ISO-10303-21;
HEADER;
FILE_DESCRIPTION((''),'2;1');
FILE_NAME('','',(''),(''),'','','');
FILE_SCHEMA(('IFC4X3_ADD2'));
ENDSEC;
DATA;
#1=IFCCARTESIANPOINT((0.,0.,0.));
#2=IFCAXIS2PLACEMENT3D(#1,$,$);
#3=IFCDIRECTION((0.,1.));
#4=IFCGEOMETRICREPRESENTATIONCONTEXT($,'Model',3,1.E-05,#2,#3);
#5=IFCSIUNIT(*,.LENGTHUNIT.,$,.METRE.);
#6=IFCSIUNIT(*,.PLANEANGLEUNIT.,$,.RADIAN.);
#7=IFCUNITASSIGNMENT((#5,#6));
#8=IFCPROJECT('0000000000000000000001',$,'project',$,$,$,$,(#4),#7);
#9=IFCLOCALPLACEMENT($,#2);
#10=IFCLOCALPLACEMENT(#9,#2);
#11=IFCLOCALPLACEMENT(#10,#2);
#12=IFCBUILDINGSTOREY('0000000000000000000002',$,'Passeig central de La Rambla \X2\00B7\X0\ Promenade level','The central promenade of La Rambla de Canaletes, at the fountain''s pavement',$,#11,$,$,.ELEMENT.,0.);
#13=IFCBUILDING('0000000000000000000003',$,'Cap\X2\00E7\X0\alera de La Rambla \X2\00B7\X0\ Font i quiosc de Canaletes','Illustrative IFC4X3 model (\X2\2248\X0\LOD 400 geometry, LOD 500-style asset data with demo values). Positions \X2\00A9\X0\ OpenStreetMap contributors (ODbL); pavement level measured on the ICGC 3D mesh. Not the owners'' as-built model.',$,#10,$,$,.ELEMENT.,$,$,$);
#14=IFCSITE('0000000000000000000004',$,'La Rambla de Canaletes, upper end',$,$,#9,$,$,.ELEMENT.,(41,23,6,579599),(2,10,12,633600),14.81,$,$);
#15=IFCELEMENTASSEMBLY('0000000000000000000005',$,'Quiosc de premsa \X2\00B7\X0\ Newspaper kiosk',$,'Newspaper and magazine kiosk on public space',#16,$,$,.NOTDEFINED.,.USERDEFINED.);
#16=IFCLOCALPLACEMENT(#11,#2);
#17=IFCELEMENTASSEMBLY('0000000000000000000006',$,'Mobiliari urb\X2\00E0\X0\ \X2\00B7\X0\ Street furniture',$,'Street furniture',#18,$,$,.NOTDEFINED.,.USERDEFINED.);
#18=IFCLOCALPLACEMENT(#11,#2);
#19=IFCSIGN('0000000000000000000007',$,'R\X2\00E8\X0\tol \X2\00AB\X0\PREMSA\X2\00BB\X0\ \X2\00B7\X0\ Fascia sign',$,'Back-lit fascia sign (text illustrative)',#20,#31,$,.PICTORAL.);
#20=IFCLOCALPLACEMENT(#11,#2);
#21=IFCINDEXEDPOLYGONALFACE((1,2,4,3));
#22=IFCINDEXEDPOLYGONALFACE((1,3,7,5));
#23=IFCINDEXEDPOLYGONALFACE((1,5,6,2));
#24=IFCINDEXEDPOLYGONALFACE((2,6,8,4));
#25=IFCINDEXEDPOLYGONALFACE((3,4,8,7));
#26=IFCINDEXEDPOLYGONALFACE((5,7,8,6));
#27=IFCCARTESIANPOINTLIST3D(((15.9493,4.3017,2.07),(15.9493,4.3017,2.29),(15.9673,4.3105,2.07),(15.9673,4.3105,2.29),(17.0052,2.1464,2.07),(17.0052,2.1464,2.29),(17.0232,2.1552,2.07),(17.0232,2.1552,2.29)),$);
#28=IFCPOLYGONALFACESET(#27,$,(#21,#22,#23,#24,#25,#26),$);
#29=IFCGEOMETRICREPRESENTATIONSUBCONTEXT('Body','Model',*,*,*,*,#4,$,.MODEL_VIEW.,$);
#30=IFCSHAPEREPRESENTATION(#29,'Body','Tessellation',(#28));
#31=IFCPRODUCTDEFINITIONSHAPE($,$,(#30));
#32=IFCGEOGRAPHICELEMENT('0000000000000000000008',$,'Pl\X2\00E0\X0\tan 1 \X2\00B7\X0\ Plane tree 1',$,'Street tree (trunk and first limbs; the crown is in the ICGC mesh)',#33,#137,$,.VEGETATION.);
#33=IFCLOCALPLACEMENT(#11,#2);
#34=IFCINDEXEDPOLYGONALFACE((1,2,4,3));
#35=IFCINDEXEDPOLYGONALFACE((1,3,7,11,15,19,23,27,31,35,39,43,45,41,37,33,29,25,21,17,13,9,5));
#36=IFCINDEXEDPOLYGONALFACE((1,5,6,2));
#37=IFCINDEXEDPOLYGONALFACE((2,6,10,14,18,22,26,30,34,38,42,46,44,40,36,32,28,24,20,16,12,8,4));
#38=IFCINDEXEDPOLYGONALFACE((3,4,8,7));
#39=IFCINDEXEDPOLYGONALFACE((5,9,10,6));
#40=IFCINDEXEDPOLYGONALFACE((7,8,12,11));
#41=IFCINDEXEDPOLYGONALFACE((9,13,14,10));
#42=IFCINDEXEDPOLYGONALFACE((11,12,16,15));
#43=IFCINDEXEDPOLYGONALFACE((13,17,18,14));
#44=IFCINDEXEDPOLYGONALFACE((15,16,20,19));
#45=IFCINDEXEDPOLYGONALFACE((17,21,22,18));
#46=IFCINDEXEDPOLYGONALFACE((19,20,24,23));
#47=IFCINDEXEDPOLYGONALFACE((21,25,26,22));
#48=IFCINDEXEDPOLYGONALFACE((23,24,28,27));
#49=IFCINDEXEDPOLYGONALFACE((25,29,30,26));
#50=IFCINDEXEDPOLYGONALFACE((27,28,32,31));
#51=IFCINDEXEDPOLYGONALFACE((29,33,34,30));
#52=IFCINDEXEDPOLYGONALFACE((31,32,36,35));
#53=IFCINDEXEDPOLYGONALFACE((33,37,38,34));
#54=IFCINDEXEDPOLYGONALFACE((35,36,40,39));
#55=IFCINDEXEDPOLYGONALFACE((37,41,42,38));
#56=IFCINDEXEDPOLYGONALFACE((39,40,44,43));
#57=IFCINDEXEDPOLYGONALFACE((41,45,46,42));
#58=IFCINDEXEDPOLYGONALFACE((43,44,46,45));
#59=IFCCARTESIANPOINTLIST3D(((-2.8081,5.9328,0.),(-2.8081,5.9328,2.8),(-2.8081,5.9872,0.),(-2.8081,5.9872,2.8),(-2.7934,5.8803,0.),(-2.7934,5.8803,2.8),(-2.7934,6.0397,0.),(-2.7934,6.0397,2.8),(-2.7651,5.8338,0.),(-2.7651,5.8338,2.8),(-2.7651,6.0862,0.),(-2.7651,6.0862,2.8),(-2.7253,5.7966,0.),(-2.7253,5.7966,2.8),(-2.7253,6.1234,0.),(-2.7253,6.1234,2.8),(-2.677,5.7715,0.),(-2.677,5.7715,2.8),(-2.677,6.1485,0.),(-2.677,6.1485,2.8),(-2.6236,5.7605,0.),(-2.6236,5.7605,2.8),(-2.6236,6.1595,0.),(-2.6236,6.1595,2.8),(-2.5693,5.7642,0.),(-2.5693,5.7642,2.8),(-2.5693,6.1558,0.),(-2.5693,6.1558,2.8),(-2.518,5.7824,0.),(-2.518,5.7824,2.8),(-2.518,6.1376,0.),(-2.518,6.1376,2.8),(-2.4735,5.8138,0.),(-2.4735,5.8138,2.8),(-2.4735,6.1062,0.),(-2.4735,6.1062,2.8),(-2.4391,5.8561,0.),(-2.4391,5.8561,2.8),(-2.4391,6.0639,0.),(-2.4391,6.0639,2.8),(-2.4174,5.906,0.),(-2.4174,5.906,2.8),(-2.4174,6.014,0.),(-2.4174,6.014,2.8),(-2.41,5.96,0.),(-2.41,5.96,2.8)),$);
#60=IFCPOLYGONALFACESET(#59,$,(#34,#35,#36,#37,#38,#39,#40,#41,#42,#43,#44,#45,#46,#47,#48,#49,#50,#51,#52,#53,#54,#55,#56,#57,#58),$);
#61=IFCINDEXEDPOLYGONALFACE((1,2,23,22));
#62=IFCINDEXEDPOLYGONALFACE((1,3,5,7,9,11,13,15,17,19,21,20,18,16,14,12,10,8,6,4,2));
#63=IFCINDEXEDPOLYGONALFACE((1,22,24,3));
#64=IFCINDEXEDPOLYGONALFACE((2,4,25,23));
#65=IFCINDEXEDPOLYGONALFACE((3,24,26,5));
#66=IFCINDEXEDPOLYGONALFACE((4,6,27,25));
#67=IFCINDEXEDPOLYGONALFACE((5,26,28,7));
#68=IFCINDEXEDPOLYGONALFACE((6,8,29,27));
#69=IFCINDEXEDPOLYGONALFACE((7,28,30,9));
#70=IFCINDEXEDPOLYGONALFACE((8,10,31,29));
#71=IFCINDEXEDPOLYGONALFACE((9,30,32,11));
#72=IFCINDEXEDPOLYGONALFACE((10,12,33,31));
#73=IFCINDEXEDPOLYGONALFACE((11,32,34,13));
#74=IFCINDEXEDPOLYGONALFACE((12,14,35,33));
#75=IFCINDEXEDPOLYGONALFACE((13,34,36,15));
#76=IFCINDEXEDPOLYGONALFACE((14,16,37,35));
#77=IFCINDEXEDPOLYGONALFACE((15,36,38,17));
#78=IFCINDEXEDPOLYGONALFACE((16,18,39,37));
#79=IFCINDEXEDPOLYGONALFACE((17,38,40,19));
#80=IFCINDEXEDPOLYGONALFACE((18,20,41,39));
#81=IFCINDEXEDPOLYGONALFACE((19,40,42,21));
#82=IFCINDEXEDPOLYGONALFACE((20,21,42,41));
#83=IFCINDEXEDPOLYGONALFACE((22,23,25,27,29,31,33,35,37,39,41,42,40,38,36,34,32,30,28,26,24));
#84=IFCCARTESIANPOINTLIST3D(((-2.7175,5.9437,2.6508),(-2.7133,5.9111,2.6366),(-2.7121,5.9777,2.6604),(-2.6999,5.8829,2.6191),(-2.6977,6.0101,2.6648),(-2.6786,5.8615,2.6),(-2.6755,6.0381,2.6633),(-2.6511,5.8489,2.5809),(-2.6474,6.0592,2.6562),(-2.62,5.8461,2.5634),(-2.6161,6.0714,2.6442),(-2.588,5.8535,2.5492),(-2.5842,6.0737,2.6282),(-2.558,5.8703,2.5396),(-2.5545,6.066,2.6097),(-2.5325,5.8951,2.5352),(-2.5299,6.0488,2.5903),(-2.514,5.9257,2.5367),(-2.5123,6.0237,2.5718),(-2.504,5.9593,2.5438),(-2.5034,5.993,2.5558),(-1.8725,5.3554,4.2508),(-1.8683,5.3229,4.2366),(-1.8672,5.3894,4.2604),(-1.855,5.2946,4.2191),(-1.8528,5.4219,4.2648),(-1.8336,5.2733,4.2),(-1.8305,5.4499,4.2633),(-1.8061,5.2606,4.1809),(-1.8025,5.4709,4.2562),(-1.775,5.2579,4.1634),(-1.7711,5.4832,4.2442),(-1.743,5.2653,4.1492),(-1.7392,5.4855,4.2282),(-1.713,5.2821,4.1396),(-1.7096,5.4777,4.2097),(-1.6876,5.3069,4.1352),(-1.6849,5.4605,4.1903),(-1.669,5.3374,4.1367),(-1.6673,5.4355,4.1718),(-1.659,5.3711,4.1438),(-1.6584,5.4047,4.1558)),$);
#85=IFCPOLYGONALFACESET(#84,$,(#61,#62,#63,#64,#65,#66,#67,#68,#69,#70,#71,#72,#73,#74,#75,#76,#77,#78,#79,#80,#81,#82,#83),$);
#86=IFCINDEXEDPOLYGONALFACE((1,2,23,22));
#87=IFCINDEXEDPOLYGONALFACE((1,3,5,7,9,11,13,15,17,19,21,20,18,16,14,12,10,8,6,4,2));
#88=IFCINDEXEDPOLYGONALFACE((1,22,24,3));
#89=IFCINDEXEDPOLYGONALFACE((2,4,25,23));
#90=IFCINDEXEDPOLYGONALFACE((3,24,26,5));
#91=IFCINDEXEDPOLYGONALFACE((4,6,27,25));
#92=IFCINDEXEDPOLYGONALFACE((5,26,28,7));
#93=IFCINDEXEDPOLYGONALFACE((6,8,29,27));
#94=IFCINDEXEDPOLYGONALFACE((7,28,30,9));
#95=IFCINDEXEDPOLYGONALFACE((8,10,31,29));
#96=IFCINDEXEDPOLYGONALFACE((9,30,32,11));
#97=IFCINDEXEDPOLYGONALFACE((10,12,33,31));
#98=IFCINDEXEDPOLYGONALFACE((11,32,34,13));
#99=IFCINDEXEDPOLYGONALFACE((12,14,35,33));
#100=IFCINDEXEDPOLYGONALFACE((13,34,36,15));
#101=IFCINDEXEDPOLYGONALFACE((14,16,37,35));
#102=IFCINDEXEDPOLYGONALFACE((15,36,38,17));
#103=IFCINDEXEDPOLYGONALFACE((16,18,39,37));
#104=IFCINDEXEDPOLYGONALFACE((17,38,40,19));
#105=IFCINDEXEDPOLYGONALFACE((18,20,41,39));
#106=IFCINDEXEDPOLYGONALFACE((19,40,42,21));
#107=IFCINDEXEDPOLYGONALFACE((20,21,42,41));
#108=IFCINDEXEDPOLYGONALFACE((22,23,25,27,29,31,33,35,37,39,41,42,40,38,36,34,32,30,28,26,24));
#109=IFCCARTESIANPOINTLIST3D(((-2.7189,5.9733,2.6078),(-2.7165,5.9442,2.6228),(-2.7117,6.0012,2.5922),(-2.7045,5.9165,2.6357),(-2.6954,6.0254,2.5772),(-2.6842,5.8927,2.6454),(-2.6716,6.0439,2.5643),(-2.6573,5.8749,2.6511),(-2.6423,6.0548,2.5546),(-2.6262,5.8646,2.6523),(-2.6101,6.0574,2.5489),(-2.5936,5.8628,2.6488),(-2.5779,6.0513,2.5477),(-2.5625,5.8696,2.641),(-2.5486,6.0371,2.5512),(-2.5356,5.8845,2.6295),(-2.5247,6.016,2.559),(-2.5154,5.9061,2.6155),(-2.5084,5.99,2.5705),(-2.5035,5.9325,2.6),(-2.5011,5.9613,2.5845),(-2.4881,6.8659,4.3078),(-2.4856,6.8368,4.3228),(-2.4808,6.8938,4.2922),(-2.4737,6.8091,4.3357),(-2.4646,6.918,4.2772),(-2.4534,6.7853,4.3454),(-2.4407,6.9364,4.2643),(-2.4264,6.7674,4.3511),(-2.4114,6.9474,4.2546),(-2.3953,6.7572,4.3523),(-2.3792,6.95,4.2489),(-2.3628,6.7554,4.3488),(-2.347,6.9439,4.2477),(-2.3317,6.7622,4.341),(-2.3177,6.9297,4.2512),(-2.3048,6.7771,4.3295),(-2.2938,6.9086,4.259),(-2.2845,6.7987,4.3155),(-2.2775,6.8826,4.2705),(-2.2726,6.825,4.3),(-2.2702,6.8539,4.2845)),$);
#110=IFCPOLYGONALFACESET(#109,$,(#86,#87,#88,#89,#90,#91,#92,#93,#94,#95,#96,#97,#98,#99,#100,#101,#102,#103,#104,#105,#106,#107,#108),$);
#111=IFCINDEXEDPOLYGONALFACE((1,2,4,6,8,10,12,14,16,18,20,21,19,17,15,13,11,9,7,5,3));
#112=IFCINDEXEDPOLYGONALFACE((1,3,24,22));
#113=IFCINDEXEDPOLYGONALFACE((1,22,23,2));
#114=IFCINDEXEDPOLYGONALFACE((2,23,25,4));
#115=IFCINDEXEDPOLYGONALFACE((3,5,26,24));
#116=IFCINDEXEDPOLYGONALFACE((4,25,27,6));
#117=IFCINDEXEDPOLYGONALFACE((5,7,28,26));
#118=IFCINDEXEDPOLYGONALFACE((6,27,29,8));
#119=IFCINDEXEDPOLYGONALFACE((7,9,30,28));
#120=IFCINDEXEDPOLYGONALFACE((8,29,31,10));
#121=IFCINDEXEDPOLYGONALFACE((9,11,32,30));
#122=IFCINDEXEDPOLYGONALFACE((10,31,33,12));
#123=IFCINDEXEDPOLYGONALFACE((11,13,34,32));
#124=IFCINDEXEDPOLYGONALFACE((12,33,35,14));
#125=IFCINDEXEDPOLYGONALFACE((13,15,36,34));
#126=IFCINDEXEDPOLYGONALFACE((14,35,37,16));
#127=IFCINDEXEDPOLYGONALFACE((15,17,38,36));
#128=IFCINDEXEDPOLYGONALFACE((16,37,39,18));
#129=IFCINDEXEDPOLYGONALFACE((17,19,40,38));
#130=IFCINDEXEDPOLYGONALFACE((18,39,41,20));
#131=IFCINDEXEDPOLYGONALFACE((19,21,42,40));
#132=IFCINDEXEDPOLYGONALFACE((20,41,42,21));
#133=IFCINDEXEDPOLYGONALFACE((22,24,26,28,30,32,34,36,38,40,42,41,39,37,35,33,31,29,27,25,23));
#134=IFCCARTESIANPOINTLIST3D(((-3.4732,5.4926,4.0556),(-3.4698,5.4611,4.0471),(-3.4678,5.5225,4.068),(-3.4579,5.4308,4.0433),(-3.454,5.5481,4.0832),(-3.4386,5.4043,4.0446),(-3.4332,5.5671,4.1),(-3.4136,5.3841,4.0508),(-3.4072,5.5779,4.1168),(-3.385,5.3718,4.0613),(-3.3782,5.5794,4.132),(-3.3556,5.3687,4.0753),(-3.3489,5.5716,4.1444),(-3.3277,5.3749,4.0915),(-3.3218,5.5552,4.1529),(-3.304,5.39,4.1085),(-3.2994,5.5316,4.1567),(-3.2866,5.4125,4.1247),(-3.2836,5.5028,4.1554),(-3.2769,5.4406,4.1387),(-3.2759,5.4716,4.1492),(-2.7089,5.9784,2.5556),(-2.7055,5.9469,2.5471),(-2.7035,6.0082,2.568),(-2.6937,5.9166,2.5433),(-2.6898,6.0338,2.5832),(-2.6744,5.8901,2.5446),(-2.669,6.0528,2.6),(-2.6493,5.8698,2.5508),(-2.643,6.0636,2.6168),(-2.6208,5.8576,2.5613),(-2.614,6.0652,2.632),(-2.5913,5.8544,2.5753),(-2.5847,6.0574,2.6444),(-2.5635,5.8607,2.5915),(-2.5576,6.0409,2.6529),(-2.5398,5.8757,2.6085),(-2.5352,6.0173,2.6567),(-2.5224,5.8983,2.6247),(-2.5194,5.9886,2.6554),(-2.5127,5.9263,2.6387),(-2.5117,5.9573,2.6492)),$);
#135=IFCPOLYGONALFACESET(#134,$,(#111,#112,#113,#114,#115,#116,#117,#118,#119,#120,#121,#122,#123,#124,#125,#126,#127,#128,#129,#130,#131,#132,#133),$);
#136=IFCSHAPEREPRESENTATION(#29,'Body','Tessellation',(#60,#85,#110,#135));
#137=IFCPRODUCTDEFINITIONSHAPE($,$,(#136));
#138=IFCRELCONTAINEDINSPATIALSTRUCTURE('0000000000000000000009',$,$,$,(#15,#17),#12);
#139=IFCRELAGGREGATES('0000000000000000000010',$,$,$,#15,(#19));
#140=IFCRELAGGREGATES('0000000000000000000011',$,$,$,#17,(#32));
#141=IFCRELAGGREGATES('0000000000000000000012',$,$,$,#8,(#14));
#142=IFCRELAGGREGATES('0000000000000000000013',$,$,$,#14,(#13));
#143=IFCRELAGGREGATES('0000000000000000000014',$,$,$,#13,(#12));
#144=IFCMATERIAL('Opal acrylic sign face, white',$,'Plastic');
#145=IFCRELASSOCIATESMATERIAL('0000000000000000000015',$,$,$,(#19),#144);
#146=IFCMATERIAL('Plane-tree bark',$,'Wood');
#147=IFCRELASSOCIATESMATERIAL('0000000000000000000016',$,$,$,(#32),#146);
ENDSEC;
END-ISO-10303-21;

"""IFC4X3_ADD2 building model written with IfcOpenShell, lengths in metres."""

from ifc_helpers import new_model, si_unit, direction, frame, frame_2d, origin, origin_2d_with_axis, place, context, subcontext, project, spatial, rectangle, circle, extrude, material, element, aggregate, save


model = new_model("IFC4X3_ADD2")

# Units and contexts
model_context = context("Model", 3, precision=1e-05, world=origin(), true_north=direction((0.0, 1.0)))
body_context = subcontext(model_context, "Body", "Model", "MODEL_VIEW")
ifc_project = project(units=[si_unit("LENGTHUNIT", "METRE"), si_unit("PLANEANGLEUNIT", "RADIAN")], contexts=[model_context])

# Site, building, storey
site_placement = place(None, origin())
site = spatial("IfcSite", under=ifc_project, at=site_placement, Name="La Rambla de Canaletes, upper end", CompositionType="ELEMENT", RefLatitude=(41, 23, 6, 579599), RefLongitude=(2, 10, 12, 633600), RefElevation=14.81)
building_placement = place(site_placement, origin())
building = spatial("IfcBuilding", under=site, at=building_placement, Name="Capçalera de La Rambla · Font i quiosc de Canaletes", Description="Illustrative IFC4X3 model (≈LOD 400 geometry, LOD 500-style asset data with demo values). Positions © OpenStreetMap contributors (ODbL); pavement level measured on the ICGC 3D mesh. Not the owners' as-built model.", CompositionType="ELEMENT")
storey_placement = place(building_placement, origin())
storey = spatial("IfcBuildingStorey", under=building, at=storey_placement, Name="Passeig central de La Rambla · Promenade level", Description="The central promenade of La Rambla de Canaletes, at the fountain's pavement", CompositionType="ELEMENT", Elevation=0.0)

# Element assembly
assembly_1_placement = place(building_placement, origin())
assembly_1 = element("IfcElementAssembly", 1, at=assembly_1_placement, inside=storey, Name="Quiosc de premsa · Newspaper kiosk", ObjectType="Newspaper and magazine kiosk on public space", AssemblyPlace="NOTDEFINED", PredefinedType="USERDEFINED")

# Element assembly
assembly_2_placement = place(building_placement, origin())
assembly_2 = element("IfcElementAssembly", 2, at=assembly_2_placement, inside=storey, Name="Mobiliari urbà · Street furniture", ObjectType="Street furniture", AssemblyPlace="NOTDEFINED", PredefinedType="USERDEFINED")

# Sign
ifc_material_1 = material(Name="Opal acrylic sign face, white", Category="Plastic")
sign_placement = place(building_placement, origin())
sign = element("IfcSign", 3, at=sign_placement, material=ifc_material_1, Name="Rètol «PREMSA» · Fascia sign", ObjectType="Back-lit fascia sign (text illustrative)", PredefinedType="PICTORAL", context=body_context, shape_type="SweptSolid", body=[
    extrude(rectangle(XDim=2.4, YDim=0.02, at=frame_2d((0.0, 0.0), x_axis=(0.439939, -0.898028))), frame((16.4862, 3.2285, 2.07)), (0.0, 0.0, 1.0), 0.22),
])
aggregate(assembly_1, [sign])

# Geographic element
ifc_material_2 = material(Name="Plane-tree bark", Category="Wood")
geographic_element_1_placement = place(building_placement, origin())
geographic_element_1 = element("IfcGeographicElement", 4, at=geographic_element_1_placement, material=ifc_material_2, Name="Plàtan 1 · Plane tree 1", ObjectType="Street tree (trunk and first limbs; the crown is in the ICGC mesh)", PredefinedType="VEGETATION", context=body_context, shape_type="SweptSolid", body=[
    extrude(circle(Radius=0.2, at=origin_2d_with_axis()), frame((-2.61, 5.96, 0.0)), (0.0, 0.0, 1.0), 2.8),
    extrude(circle(Radius=0.12, at=origin_2d_with_axis()), frame((-2.61, 5.96, 2.6), z_axis=(0.444101, -0.30918, 0.840941), x_axis=(-0.571364, -0.820697, 0.0)), (0.0, 0.0, 1.0), 1.9026),
    extrude(circle(Radius=0.11, at=origin_2d_with_axis()), frame((-2.61, 5.96, 2.6), z_axis=(0.119374, 0.461544, 0.879049), x_axis=(0.968142, -0.250402, 0.0)), (0.0, 0.0, 1.0), 1.9339),
    extrude(circle(Radius=0.11, at=origin_2d_with_axis()), frame((-2.61, 5.96, 2.6), z_axis=(-0.43617, -0.277231, 0.856095), x_axis=(-0.536419, 0.843952, 0.0)), (0.0, 0.0, 1.0), 1.7521),
])
aggregate(assembly_2, [geographic_element_1])

save(model, "model.ifc")
